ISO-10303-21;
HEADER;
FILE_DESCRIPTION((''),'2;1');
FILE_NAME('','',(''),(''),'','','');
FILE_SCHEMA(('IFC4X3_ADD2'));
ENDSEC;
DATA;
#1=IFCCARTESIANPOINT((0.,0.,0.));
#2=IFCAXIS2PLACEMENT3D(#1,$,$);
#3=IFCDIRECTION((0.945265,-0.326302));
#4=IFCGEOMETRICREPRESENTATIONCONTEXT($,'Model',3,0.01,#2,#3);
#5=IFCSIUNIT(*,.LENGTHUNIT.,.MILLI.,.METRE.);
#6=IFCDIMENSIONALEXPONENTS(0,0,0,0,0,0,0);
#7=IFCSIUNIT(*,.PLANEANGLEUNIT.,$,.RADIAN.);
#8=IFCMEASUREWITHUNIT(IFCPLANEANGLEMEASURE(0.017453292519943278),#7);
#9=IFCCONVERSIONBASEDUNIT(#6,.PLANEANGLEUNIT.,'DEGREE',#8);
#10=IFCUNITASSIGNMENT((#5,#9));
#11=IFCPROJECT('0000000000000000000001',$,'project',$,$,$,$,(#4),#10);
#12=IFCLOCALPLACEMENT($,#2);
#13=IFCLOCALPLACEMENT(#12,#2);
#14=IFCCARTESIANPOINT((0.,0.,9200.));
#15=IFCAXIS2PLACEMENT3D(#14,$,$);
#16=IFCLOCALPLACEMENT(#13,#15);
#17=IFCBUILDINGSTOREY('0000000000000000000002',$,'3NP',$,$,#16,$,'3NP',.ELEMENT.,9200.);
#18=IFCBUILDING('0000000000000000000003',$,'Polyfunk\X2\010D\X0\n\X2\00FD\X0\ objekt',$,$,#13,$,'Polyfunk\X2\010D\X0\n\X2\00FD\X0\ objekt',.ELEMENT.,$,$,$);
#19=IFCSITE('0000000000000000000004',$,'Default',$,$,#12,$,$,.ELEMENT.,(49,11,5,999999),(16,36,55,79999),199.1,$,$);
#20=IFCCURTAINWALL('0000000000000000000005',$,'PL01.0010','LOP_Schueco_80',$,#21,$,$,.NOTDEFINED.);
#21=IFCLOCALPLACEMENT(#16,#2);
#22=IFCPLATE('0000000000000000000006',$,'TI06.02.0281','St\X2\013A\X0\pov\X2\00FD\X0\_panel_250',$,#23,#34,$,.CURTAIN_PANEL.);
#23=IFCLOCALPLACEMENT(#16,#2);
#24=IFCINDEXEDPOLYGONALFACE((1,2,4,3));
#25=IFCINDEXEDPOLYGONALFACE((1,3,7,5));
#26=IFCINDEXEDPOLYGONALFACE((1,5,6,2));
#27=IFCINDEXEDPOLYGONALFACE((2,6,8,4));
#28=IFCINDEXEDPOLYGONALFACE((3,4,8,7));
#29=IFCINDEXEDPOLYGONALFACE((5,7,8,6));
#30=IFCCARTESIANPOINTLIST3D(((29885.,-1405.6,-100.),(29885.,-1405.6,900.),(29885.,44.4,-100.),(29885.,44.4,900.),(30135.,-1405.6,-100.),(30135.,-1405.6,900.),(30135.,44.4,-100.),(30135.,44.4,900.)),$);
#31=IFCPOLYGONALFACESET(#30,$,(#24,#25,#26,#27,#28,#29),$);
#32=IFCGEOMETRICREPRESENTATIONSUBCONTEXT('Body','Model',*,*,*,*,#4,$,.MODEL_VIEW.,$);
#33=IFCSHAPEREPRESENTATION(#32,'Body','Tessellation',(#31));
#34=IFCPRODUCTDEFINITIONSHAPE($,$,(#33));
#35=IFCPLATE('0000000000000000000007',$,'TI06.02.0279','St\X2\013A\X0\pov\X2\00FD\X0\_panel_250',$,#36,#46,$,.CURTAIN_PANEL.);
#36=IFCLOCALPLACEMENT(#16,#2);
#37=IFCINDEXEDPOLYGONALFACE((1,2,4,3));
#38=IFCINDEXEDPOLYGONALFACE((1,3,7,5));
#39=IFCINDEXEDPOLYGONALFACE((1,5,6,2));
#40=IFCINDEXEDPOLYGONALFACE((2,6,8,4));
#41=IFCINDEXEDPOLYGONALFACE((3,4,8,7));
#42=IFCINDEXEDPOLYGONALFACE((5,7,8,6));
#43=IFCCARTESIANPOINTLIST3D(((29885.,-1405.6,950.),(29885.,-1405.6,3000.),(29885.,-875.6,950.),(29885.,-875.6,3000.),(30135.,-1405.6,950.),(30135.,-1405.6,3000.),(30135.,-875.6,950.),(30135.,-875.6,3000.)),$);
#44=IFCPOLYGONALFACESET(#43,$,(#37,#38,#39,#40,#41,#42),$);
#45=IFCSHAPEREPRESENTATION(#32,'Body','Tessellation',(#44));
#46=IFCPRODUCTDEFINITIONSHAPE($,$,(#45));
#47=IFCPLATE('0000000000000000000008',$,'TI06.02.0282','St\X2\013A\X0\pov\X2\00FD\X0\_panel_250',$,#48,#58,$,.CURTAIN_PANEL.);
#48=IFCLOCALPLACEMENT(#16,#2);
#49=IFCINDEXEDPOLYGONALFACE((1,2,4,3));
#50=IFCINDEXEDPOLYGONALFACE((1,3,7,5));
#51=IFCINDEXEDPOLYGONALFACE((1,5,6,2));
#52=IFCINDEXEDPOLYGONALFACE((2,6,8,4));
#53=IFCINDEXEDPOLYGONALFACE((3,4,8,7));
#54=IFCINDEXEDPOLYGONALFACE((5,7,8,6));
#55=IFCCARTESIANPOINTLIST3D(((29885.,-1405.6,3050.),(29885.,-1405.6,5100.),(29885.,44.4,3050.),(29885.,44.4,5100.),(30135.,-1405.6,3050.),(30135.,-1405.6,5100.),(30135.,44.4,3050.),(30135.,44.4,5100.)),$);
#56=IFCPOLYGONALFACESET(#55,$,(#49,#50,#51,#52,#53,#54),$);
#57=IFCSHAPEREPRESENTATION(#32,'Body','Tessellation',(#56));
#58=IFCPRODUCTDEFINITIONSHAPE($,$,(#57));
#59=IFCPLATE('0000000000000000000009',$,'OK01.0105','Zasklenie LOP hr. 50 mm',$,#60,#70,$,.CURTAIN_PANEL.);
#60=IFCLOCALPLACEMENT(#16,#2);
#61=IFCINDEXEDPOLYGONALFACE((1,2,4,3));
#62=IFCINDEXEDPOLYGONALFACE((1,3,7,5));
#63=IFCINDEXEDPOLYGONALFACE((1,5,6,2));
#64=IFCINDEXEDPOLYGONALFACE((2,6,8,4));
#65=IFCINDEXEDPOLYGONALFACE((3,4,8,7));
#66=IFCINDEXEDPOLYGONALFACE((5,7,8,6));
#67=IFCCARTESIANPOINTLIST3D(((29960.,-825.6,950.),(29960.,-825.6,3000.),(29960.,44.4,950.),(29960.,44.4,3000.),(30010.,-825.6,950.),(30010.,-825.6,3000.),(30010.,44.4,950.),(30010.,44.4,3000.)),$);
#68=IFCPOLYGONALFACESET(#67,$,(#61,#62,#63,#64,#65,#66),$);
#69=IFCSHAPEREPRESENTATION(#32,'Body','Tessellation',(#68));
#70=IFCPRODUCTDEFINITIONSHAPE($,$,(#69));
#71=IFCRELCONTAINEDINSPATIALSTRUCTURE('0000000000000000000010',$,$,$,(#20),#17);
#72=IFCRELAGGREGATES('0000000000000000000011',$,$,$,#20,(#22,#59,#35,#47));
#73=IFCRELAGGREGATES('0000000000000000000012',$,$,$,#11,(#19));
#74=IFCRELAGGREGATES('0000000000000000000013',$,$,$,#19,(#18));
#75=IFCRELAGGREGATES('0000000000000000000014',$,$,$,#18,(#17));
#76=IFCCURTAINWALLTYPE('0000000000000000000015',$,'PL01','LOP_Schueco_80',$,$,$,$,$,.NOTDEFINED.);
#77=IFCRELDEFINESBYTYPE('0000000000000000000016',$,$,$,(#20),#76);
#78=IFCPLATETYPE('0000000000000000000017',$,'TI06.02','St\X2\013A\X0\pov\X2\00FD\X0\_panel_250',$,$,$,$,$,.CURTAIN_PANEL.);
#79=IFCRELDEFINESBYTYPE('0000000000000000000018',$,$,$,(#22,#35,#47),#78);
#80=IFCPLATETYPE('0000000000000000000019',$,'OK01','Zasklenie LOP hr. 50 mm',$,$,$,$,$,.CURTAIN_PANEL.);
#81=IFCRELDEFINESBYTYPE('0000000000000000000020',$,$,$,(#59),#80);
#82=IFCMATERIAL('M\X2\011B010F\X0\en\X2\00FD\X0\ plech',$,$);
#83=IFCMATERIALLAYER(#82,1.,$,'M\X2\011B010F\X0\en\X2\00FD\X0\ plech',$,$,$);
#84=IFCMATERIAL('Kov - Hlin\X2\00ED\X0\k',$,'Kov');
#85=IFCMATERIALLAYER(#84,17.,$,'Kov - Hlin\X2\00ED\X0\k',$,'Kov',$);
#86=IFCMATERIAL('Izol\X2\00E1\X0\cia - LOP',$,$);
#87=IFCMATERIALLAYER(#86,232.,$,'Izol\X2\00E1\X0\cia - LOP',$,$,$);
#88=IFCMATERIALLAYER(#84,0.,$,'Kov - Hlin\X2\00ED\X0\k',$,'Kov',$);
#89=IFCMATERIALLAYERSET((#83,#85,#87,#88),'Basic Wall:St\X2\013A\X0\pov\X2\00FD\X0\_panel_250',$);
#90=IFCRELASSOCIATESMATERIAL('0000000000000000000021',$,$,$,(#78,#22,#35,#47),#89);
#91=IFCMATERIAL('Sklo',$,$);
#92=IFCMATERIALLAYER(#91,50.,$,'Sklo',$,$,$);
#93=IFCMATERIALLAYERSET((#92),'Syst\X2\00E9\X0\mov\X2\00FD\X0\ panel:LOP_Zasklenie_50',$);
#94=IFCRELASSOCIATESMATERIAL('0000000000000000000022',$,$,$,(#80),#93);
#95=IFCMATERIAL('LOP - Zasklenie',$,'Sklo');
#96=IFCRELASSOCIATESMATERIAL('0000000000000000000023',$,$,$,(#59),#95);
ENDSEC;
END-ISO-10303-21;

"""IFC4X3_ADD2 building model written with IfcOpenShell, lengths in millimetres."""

from ifc_helpers import new_model, entity, si_unit, converted_unit, direction, frame, frame_2d, origin, origin_2d_with_axis, place, context, subcontext, project, spatial, rectangle, extrude, source, transform, mapped, material, layer, layer_set, layer_usage, type_object, type_shapes, element, aggregate, save


model = new_model("IFC4X3_ADD2")

# Units and contexts
model_context = context("Model", 3, precision=0.01, world=origin(), true_north=direction((0.945265, -0.326302)))
body_context = subcontext(model_context, "Body", "Model", "MODEL_VIEW")
ifc_project = project(units=[si_unit("LENGTHUNIT", "METRE", prefix="MILLI"), converted_unit("PLANEANGLEUNIT", "DEGREE", entity("IfcPlaneAngleMeasure", 0.017453292519943278), si_unit("PLANEANGLEUNIT", "RADIAN"), dimensions=[0, 0, 0, 0, 0, 0, 0])], contexts=[model_context])

# Site, building, storey
site_placement = place(None, origin())
site = spatial("IfcSite", under=ifc_project, at=site_placement, Name="Default", CompositionType="ELEMENT", RefLatitude=(49, 11, 5, 999999), RefLongitude=(16, 36, 55, 79999), RefElevation=199.1)
building_placement = place(site_placement, origin())
building = spatial("IfcBuilding", under=site, at=building_placement, Name="Polyfunkčný objekt", LongName="Polyfunkčný objekt", CompositionType="ELEMENT")
storey_placement = place(building_placement, frame((0.0, 0.0, 9200.0)))
storey = spatial("IfcBuildingStorey", under=building, at=storey_placement, Name="3NP", LongName="3NP", CompositionType="ELEMENT", Elevation=9200.0)

# Curtain wall, plates
curtain_wall_type = type_object("IfcCurtainWallType", Name="PL01", Description="LOP_Schueco_80", PredefinedType="NOTDEFINED")
curtain_wall_placement = place(storey_placement, frame((0.0, 0.0, -9200.0)))
curtain_wall = element("IfcCurtainWall", 1, at=curtain_wall_placement, inside=storey, type_object=curtain_wall_type, Name="PL01.0010", Description="LOP_Schueco_80", PredefinedType="NOTDEFINED")
ifc_material_1 = material(Name="Měďený plech")
ifc_layer_1 = layer(ifc_material_1, 1.0, Name="Měďený plech")
ifc_material_2 = material(Name="Kov - Hliník", Category="Kov")
ifc_layer_2 = layer(ifc_material_2, 17.0, Name="Kov - Hliník", Category="Kov")
ifc_material_3 = material(Name="Izolácia - LOP")
ifc_layer_3 = layer(ifc_material_3, 232.0, Name="Izolácia - LOP")
ifc_layer_4 = layer(ifc_material_2, 0.0, Name="Kov - Hliník", Category="Kov")
ifc_layer_set_1 = layer_set([ifc_layer_1, ifc_layer_2, ifc_layer_3, ifc_layer_4], Name="Basic Wall:Stĺpový_panel_250")
ifc_layer_usage_1 = layer_usage(ifc_layer_set_1, "AXIS2", "POSITIVE", -125.0)
plate_type_1 = type_object("IfcPlateType", Name="TI06.02", Description="Stĺpový_panel_250", PredefinedType="CURTAIN_PANEL", material=ifc_layer_set_1)
plate_1_placement = place(storey_placement, frame((30010.0, 44.4, -100.0), z_axis=(0.0, 0.0, 1.0), x_axis=(0.0, -1.0, 0.0)))
plate_1 = element("IfcPlate", 2, at=plate_1_placement, type_object=plate_type_1, material=ifc_layer_usage_1, Name="TI06.02.0281", Description="Stĺpový_panel_250", PredefinedType="CURTAIN_PANEL", context=body_context, shape_type="SweptSolid", body=[
    extrude(rectangle(XDim=250.0, YDim=1450.0, at=frame_2d((0.0, 0.0), x_axis=(1.0, 0.0))), frame((725.0, 0.0, 0.0), z_axis=(0.0, 0.0, 1.0), x_axis=(0.0, 1.0, 0.0)), (0.0, 0.0, 1.0), 1000.0),
])
ifc_layer_usage_2 = layer_usage(ifc_layer_set_1, "AXIS2", "POSITIVE", -125.0)
plate_2_placement = place(storey_placement, frame((30010.0, -875.6, 950.0), z_axis=(0.0, 0.0, 1.0), x_axis=(0.0, -1.0, 0.0)))
plate_2 = element("IfcPlate", 3, at=plate_2_placement, type_object=plate_type_1, material=ifc_layer_usage_2, Name="TI06.02.0279", Description="Stĺpový_panel_250", PredefinedType="CURTAIN_PANEL", context=body_context, shape_type="SweptSolid", body=[
    extrude(rectangle(XDim=250.0, YDim=530.0, at=frame_2d((0.0, 0.0), x_axis=(1.0, 0.0))), frame((265.0, 0.0, 0.0), z_axis=(0.0, 0.0, 1.0), x_axis=(0.0, 1.0, 0.0)), (0.0, 0.0, 1.0), 2050.0),
])
ifc_layer_usage_3 = layer_usage(ifc_layer_set_1, "AXIS2", "POSITIVE", -125.0)
plate_3_placement = place(storey_placement, frame((30010.0, 44.4, 3050.0), z_axis=(0.0, 0.0, 1.0), x_axis=(0.0, -1.0, 0.0)))
plate_3 = element("IfcPlate", 4, at=plate_3_placement, type_object=plate_type_1, material=ifc_layer_usage_3, Name="TI06.02.0282", Description="Stĺpový_panel_250", PredefinedType="CURTAIN_PANEL", context=body_context, shape_type="SweptSolid", body=[
    extrude(rectangle(XDim=250.0, YDim=1450.0, at=frame_2d((0.0, 0.0), x_axis=(1.0, 0.0))), frame((725.0, 0.0, 0.0), z_axis=(0.0, 0.0, 1.0), x_axis=(0.0, 1.0, 0.0)), (0.0, 0.0, 1.0), 2050.0),
])
ifc_material_4 = material(Name="LOP - Zasklenie", Category="Sklo")
ifc_material_5 = material(Name="Sklo")
ifc_layer_5 = layer(ifc_material_5, 50.0, Name="Sklo")
ifc_layer_set_2 = layer_set([ifc_layer_5], Name="Systémový panel:LOP_Zasklenie_50")
plate_type_2 = type_object("IfcPlateType", Name="OK01", Description="Zasklenie LOP hr. 50 mm", PredefinedType="CURTAIN_PANEL", material=ifc_layer_set_2)
shared_shape_1 = source(origin(), body_context, "Body", "SweptSolid", [
    extrude(rectangle(XDim=50.0, YDim=870.0, at=origin_2d_with_axis()), frame((0.0, -25.0, 0.0), z_axis=(0.0, 0.0, 1.0), x_axis=(0.0, 1.0, 0.0)), (0.0, 0.0, 1.0), 2050.0),
])
type_shapes(plate_type_2, [shared_shape_1])
plate_4_placement = place(curtain_wall_placement, frame((30010.0, -390.6, 10150.0), z_axis=(0.0, 0.0, 1.0), x_axis=(0.0, -1.0, 0.0)))
plate_4 = element("IfcPlate", 5, at=plate_4_placement, type_object=plate_type_2, material=ifc_material_4, Name="OK01.0105", Description="Zasklenie LOP hr. 50 mm", PredefinedType="CURTAIN_PANEL", context=body_context, shape_type="MappedRepresentation", body=[
    mapped(shared_shape_1, transform((0.0, 0.0, 0.0), scale=1.0)),
])
aggregate(curtain_wall, [plate_1, plate_4, plate_2, plate_3])

save(model, "model.ifc")
